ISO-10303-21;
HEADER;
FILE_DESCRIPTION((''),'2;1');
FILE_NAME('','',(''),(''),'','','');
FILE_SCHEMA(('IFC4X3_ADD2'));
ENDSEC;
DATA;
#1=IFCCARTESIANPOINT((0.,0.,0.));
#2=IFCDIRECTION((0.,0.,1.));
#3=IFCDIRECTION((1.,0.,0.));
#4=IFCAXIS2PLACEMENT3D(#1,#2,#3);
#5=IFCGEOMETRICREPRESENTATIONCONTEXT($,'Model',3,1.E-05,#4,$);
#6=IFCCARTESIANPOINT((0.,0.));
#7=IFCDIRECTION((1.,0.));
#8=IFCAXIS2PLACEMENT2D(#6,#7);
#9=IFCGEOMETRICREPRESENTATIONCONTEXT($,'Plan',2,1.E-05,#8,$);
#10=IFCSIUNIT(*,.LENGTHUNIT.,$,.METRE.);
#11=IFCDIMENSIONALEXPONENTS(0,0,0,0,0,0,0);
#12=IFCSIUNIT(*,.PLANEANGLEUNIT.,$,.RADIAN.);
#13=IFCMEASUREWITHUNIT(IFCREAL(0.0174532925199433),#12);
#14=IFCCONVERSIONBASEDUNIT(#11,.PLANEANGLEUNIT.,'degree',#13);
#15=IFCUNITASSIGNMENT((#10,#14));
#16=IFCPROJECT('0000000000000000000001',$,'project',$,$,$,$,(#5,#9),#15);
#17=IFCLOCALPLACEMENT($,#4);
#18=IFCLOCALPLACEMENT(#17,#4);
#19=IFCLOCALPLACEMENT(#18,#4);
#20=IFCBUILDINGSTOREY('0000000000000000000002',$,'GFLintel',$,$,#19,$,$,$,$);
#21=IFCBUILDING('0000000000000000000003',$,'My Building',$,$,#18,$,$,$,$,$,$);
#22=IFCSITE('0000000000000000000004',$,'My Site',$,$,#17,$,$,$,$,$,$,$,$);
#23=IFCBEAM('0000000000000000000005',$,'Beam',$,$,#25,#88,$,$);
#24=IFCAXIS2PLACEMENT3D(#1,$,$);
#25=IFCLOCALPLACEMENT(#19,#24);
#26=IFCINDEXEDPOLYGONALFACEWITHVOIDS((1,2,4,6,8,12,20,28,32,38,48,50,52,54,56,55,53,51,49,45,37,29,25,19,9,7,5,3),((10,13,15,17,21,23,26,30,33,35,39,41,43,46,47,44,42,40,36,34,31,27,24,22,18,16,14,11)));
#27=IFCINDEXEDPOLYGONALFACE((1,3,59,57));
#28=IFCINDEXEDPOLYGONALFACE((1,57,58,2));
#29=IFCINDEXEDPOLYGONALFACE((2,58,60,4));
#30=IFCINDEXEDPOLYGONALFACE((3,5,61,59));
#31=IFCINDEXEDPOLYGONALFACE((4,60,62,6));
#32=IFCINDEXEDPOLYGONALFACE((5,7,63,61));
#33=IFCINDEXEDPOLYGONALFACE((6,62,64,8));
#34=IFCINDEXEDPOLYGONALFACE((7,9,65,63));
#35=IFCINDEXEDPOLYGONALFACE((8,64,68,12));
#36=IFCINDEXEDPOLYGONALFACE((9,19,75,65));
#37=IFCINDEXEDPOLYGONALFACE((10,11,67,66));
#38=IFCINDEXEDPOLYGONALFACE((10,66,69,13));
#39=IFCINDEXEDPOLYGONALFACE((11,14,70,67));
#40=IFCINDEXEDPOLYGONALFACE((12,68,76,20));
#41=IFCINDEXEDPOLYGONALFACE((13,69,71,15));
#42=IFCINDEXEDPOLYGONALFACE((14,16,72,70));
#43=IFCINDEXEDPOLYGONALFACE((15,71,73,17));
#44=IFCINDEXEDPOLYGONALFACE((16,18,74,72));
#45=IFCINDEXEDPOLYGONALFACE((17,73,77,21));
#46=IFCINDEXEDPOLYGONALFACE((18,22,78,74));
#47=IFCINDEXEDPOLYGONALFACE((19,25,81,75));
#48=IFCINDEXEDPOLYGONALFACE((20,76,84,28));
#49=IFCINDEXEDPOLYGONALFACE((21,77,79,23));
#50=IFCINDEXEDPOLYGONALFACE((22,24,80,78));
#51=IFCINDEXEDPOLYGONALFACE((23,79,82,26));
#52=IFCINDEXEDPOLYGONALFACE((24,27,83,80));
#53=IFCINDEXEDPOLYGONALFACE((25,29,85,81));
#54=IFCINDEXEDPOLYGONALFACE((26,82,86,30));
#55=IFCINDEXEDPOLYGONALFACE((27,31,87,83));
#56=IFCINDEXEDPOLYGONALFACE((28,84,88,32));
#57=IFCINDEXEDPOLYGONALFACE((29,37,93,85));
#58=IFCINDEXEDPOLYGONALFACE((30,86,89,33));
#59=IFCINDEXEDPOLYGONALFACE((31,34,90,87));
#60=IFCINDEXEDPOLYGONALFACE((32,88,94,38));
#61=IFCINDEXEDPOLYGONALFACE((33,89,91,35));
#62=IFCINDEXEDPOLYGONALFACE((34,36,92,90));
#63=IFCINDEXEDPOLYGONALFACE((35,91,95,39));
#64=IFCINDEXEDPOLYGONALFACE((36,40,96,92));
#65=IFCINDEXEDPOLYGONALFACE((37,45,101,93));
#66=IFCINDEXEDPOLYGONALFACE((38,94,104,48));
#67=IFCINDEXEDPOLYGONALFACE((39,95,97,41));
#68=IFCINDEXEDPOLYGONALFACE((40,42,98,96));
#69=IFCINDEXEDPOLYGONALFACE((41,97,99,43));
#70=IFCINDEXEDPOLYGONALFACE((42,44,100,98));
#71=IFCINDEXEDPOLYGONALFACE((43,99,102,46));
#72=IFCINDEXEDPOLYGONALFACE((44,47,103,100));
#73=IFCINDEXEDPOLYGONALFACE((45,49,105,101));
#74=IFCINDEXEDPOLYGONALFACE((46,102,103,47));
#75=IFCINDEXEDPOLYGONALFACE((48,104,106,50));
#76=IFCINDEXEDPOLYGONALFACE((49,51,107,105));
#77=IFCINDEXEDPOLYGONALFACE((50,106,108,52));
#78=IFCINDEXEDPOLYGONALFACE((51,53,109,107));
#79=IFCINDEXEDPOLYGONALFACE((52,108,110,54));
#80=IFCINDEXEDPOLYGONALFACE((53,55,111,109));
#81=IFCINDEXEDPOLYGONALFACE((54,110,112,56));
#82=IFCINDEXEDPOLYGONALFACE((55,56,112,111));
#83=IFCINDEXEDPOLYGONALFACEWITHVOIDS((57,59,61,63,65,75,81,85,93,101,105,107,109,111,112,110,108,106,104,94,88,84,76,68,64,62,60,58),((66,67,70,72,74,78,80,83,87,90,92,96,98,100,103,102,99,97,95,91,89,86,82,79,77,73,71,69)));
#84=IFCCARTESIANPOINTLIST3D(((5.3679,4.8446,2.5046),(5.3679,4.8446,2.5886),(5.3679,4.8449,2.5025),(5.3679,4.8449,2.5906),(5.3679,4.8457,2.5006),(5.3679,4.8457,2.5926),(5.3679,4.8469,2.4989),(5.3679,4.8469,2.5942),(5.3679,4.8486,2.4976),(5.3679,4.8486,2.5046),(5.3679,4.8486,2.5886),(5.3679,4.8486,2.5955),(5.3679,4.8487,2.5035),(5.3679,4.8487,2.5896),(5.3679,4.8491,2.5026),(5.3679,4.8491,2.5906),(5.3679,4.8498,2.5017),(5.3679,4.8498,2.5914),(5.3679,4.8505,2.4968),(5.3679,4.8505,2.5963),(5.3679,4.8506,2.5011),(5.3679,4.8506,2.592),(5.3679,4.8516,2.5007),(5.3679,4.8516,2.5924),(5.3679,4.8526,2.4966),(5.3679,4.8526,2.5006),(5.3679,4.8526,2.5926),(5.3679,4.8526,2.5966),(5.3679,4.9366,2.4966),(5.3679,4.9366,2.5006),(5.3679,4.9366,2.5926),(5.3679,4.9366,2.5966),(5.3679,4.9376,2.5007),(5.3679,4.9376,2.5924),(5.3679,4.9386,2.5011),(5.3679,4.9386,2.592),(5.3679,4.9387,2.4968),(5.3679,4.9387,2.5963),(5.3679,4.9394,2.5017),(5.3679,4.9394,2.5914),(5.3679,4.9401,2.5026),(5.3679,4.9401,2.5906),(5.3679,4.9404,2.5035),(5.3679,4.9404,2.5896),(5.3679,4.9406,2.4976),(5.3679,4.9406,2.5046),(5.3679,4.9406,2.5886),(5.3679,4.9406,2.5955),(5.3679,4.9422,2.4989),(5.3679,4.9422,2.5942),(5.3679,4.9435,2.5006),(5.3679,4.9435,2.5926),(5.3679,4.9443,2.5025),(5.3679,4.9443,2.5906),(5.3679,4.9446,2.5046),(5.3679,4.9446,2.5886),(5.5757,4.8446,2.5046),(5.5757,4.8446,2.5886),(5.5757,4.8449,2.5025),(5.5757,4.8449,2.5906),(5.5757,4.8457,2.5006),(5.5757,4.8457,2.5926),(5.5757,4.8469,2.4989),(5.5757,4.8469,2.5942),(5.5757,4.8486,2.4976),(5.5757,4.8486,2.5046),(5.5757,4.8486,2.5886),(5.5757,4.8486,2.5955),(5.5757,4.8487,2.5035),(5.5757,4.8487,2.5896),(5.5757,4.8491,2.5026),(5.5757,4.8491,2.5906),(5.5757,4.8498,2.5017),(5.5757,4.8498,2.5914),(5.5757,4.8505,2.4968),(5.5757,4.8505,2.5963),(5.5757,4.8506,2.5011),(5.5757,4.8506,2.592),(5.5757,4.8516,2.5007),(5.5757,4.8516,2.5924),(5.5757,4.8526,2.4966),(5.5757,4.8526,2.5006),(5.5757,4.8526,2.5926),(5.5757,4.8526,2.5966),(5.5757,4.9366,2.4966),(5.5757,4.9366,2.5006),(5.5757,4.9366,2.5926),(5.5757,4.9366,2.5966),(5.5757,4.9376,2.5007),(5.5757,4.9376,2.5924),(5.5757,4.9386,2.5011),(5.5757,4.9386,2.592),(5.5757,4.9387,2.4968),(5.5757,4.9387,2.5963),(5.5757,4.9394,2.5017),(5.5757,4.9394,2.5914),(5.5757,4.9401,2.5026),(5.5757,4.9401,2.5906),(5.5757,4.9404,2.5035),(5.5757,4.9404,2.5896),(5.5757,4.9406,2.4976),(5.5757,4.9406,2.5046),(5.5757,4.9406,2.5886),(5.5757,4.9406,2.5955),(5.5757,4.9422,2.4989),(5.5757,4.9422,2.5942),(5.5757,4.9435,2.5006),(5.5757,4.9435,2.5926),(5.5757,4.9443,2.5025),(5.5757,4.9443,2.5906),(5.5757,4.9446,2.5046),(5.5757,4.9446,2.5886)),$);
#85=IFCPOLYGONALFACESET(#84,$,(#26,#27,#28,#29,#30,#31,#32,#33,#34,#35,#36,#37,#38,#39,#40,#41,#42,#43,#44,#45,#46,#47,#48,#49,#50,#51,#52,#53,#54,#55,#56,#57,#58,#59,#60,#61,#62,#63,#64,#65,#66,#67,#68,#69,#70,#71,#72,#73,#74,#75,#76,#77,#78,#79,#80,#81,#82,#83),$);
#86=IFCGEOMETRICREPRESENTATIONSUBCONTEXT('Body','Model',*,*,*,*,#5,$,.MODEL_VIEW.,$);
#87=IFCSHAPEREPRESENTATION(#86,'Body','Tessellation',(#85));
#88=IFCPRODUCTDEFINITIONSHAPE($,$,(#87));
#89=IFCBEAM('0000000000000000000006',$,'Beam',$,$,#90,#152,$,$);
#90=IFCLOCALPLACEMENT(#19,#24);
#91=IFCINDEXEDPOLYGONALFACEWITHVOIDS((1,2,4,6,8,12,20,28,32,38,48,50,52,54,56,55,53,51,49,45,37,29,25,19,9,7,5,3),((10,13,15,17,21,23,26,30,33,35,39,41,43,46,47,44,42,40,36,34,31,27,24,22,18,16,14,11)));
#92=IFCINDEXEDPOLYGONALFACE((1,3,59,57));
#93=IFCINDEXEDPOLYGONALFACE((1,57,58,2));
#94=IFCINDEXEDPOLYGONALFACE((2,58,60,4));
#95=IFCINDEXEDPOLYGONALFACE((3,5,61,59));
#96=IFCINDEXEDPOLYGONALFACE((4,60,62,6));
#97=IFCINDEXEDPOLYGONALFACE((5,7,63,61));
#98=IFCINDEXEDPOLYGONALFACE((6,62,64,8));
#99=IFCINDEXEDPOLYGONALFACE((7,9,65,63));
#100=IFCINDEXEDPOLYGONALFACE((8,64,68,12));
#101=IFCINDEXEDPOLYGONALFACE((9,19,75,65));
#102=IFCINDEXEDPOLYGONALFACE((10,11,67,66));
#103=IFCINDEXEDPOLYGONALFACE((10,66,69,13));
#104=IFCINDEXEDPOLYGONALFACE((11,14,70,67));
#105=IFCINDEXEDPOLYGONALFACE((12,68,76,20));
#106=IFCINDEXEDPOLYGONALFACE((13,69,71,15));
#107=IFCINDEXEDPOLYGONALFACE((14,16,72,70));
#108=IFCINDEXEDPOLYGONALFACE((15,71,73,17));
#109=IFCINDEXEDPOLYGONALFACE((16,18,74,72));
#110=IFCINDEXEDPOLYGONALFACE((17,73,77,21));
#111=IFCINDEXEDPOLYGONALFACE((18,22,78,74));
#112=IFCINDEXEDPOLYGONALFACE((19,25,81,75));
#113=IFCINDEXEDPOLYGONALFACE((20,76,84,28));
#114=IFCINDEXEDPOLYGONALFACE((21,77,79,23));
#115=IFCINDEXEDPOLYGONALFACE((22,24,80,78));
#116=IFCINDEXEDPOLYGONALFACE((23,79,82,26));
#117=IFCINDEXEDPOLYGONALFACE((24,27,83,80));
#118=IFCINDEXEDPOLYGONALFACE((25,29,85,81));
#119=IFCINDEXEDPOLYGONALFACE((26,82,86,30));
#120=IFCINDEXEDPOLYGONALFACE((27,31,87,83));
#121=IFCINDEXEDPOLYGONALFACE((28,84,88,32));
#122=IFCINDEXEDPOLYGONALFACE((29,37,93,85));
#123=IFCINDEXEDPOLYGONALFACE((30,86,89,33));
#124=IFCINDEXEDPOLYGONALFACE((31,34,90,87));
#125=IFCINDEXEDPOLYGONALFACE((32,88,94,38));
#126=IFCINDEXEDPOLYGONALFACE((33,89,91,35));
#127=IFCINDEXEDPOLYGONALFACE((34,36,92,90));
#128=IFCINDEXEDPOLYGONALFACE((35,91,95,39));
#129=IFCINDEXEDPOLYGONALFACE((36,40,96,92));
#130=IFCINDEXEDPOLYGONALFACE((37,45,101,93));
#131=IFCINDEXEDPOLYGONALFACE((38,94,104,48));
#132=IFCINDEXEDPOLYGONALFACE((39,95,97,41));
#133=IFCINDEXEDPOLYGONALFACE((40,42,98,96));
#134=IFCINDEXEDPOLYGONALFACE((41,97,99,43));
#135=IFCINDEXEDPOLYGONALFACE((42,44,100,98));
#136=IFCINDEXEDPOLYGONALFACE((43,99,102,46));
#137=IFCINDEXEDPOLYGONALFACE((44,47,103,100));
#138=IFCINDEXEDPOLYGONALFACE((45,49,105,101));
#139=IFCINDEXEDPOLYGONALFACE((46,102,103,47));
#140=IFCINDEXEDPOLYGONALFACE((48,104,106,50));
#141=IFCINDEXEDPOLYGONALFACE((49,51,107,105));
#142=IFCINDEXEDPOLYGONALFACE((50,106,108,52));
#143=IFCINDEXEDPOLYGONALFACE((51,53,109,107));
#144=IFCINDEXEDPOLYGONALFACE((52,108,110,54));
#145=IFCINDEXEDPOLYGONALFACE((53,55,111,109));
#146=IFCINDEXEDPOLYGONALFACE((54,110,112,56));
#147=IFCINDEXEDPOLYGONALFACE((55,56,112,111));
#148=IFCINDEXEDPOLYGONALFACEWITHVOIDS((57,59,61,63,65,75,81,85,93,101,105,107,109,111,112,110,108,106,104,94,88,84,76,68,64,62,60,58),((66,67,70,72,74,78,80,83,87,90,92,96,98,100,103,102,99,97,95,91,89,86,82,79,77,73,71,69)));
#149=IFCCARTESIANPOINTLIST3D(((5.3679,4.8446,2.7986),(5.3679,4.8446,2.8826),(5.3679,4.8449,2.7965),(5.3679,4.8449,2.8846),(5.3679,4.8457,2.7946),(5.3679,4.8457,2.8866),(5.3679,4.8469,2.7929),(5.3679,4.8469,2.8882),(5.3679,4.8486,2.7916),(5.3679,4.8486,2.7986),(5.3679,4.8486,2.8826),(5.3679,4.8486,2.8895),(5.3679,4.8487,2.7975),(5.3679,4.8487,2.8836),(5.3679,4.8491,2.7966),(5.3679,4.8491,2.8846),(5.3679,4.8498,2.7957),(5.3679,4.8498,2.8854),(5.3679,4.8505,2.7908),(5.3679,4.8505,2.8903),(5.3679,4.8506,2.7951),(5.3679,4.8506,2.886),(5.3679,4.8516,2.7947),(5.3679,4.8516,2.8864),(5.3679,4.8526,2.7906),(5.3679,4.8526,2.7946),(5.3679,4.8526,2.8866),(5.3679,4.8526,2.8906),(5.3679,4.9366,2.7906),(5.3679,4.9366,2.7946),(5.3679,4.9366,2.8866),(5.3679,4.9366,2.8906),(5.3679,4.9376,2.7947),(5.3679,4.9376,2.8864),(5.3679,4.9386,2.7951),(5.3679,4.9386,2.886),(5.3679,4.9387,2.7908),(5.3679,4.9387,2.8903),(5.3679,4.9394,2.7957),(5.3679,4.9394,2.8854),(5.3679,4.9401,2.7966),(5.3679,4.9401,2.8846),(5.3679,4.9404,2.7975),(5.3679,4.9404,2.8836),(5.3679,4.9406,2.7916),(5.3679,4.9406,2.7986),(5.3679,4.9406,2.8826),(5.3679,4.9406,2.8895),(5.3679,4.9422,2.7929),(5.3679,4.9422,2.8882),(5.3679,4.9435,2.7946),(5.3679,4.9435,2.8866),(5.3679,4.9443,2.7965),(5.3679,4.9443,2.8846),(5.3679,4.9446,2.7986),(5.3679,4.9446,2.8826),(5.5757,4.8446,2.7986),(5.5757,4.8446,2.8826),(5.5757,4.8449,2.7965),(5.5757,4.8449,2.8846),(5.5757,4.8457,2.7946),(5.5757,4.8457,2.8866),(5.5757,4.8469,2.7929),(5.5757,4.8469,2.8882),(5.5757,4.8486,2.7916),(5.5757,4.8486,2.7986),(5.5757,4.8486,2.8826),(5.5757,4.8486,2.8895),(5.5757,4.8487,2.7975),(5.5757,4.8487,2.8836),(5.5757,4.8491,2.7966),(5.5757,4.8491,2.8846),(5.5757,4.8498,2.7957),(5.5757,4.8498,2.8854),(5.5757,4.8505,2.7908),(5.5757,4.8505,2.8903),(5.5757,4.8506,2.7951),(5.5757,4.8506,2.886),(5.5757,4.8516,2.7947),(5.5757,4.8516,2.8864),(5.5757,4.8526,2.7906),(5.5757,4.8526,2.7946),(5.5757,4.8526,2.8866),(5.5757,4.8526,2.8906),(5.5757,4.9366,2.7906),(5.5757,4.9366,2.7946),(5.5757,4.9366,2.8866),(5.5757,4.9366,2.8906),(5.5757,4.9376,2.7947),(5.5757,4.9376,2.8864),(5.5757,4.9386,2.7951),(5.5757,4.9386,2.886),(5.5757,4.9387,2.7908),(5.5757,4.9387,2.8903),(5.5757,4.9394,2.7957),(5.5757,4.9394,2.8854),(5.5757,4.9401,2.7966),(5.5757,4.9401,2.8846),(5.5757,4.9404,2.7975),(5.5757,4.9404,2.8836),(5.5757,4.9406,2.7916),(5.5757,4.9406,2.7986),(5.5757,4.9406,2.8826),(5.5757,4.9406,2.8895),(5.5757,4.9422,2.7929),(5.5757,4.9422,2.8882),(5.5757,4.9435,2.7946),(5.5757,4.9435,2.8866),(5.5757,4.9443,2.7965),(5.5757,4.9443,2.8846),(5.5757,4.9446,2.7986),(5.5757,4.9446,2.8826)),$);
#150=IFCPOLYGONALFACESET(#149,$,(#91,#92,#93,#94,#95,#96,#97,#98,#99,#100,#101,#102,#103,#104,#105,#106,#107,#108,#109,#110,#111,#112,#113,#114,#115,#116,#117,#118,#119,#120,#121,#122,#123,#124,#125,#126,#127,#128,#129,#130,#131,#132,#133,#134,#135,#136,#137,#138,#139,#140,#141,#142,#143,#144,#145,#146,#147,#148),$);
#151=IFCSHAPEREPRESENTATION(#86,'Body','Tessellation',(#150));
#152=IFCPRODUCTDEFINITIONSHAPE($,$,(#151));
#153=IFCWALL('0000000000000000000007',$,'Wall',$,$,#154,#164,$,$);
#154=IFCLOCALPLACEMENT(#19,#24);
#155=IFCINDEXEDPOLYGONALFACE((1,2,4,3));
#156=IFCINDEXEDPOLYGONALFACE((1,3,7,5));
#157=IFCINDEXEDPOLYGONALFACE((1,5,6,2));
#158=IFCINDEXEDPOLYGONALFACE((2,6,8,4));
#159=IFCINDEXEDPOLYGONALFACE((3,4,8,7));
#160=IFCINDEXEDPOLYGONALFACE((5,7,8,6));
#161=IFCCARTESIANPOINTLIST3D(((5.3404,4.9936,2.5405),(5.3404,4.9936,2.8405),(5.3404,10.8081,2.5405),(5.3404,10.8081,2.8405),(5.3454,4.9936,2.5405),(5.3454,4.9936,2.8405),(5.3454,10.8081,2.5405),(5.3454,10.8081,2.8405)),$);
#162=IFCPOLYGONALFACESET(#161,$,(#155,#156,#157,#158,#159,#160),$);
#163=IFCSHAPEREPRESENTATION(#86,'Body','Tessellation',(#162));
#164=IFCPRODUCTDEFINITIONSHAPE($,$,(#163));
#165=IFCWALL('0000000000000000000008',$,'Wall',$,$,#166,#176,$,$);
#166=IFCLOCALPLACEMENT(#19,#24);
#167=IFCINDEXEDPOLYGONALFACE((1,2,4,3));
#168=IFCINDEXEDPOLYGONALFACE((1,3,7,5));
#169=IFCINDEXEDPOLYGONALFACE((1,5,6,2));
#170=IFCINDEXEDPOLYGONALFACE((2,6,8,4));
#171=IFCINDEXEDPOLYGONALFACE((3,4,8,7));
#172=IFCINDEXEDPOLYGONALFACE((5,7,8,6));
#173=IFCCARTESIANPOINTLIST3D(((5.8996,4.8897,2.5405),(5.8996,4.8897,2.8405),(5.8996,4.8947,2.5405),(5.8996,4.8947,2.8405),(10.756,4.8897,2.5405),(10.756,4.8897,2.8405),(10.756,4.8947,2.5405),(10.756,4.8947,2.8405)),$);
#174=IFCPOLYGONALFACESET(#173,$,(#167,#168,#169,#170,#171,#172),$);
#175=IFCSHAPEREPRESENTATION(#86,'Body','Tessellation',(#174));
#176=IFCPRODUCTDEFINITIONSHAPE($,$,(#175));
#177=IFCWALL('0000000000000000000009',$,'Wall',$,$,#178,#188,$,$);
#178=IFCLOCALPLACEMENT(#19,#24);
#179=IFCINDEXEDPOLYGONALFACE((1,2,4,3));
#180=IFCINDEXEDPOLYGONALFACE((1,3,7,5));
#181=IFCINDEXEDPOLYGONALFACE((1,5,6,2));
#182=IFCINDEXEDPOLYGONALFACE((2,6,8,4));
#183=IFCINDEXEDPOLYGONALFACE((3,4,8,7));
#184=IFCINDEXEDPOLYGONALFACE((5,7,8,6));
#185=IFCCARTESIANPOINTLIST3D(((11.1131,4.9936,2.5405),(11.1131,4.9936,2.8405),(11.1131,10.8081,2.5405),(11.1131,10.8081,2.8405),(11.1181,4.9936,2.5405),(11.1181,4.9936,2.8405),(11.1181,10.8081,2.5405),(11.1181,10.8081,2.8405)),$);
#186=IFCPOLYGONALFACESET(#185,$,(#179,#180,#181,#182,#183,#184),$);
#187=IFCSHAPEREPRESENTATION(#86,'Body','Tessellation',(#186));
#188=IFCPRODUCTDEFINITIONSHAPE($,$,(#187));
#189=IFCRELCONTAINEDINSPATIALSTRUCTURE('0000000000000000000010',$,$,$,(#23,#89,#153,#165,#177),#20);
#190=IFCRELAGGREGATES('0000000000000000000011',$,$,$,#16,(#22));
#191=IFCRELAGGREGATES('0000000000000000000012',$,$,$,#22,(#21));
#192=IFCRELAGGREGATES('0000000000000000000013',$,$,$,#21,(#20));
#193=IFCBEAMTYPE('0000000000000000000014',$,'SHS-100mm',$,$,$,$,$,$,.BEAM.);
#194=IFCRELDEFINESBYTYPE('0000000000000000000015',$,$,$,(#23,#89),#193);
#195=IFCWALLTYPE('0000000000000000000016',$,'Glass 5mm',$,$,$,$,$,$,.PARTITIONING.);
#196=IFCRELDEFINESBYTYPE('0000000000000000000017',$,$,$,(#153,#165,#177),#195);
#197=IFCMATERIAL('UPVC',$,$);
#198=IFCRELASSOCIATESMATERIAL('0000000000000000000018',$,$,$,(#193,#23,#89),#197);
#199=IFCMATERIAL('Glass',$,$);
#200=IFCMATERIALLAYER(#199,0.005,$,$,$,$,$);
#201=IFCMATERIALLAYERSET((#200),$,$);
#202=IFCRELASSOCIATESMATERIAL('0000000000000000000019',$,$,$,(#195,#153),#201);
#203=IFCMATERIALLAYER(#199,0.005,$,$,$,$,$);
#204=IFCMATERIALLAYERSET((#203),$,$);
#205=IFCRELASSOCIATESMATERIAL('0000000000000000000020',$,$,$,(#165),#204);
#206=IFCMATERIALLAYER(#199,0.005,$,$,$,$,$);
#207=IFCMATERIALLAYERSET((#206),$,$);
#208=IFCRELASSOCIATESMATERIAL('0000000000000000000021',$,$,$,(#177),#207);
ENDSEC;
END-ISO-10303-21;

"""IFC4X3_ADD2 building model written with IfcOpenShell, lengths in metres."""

from ifc_helpers import new_model, entity, si_unit, converted_unit, frame, origin_with_axes, origin_2d_with_axis, place, context, subcontext, project, spatial, line, indexed_curve, hollow_rectangle, outline, extrude, material, layer, layer_set, layer_usage, material_profile, profile_set, profile_usage, type_object, element, save


model = new_model("IFC4X3_ADD2")

# Units and contexts
model_context = context("Model", 3, precision=1e-05, world=origin_with_axes())
plan_context = context("Plan", 2, precision=1e-05, world=origin_2d_with_axis())
body_context = subcontext(model_context, "Body", "Model", "MODEL_VIEW")
ifc_project = project(units=[si_unit("LENGTHUNIT", "METRE"), converted_unit("PLANEANGLEUNIT", "degree", entity("IfcReal", 0.0174532925199433), si_unit("PLANEANGLEUNIT", "RADIAN"), dimensions=[0, 0, 0, 0, 0, 0, 0])], contexts=[model_context, plan_context])

# Site, building, storey
site_placement = place(None, origin_with_axes())
site = spatial("IfcSite", under=ifc_project, at=site_placement, Name="My Site")
building_placement = place(site_placement, origin_with_axes())
building = spatial("IfcBuilding", under=site, at=building_placement, Name="My Building")
storey_placement = place(building_placement, origin_with_axes())
storey = spatial("IfcBuildingStorey", under=building, at=storey_placement, Name="GFLintel")

# Beams
ifc_material_1 = material(Name="UPVC")
ifc_material_profile_1 = material_profile(ifc_material_1, hollow_rectangle(XDim=0.1, YDim=0.1, WallThickness=0.004, InnerFilletRadius=0.004, OuterFilletRadius=0.008))
ifc_profile_set_1 = profile_set([ifc_material_profile_1])
beam_type_1 = type_object("IfcBeamType", Name="SHS-100mm", PredefinedType="BEAM", material=ifc_profile_set_1)
ifc_profile_usage_1 = profile_usage(ifc_profile_set_1, cardinal=5)
beam_1_placement = place(storey_placement, frame((5.3679, 4.8946, 2.5466), z_axis=(1.0, 0.0, 0.000001), x_axis=(0.0, 1.0, 0.0)))
element("IfcBeam", 1, at=beam_1_placement, inside=storey, type_object=beam_type_1, material=ifc_profile_usage_1, Name="Beam", context=body_context, shape_type="SweptSolid", body=[
    extrude(hollow_rectangle(XDim=0.1, YDim=0.1, WallThickness=0.004, InnerFilletRadius=0.004, OuterFilletRadius=0.008), origin_with_axes(), (0.0, 0.0, 1.0), 0.2078),
])
ifc_profile_usage_2 = profile_usage(ifc_profile_set_1, cardinal=5)
beam_2_placement = place(storey_placement, frame((5.3679, 4.8946, 2.8406), z_axis=(1.0, 0.0, 0.000001), x_axis=(0.0, 1.0, 0.0)))
element("IfcBeam", 2, at=beam_2_placement, inside=storey, type_object=beam_type_1, material=ifc_profile_usage_2, Name="Beam", context=body_context, shape_type="SweptSolid", body=[
    extrude(hollow_rectangle(XDim=0.1, YDim=0.1, WallThickness=0.004, InnerFilletRadius=0.004, OuterFilletRadius=0.008), origin_with_axes(), (0.0, 0.0, 1.0), 0.2078),
])

# Walls
ifc_material_2 = material(Name="Glass")
ifc_layer_1 = layer(ifc_material_2, 0.005)
ifc_layer_set_1 = layer_set([ifc_layer_1])
ifc_layer_usage_1 = layer_usage(ifc_layer_set_1, "AXIS2", "POSITIVE", 0.0)
wall_type = type_object("IfcWallType", Name="Glass 5mm", PredefinedType="PARTITIONING", material=ifc_layer_set_1)
wall_1_placement = place(storey_placement, frame((5.3454, 4.9936, 2.5405), z_axis=(0.0, 0.0, 1.0), x_axis=(0.0, 1.0, 0.0)))
element("IfcWall", 3, at=wall_1_placement, inside=storey, type_object=wall_type, material=ifc_layer_usage_1, Name="Wall", context=body_context, shape_type="SweptSolid", body=[
    extrude(outline(indexed_curve([(0.0, 0.0), (0.0, 0.005), (5.8145, 0.005), (5.8145, 0.0)], segments=[line(1, 2, 3, 4, 1)])), origin_with_axes(), (0.0, 0.0, 1.0), 0.3),
])
ifc_layer_2 = layer(ifc_material_2, 0.005)
ifc_layer_set_2 = layer_set([ifc_layer_2])
ifc_layer_usage_2 = layer_usage(ifc_layer_set_2, "AXIS2", "POSITIVE", 0.0)
wall_2_placement = place(storey_placement, frame((5.8996, 4.8897, 2.5405), z_axis=(0.0, 0.0, 1.0), x_axis=(1.0, 0.0, 0.0)))
element("IfcWall", 4, at=wall_2_placement, inside=storey, type_object=wall_type, material=ifc_layer_usage_2, Name="Wall", context=body_context, shape_type="SweptSolid", body=[
    extrude(outline(indexed_curve([(0.0, 0.0), (0.0, 0.005), (4.8564, 0.005), (4.8564, 0.0)], segments=[line(1, 2, 3, 4, 1)])), origin_with_axes(), (0.0, 0.0, 1.0), 0.3),
])
ifc_layer_3 = layer(ifc_material_2, 0.005)
ifc_layer_set_3 = layer_set([ifc_layer_3])
ifc_layer_usage_3 = layer_usage(ifc_layer_set_3, "AXIS2", "POSITIVE", 0.0)
wall_3_placement = place(storey_placement, frame((11.1181, 4.9936, 2.5405), z_axis=(0.0, 0.0, 1.0), x_axis=(0.0, 1.0, 0.0)))
element("IfcWall", 5, at=wall_3_placement, inside=storey, type_object=wall_type, material=ifc_layer_usage_3, Name="Wall", context=body_context, shape_type="SweptSolid", body=[
    extrude(outline(indexed_curve([(0.0, 0.0), (0.0, 0.005), (5.8145, 0.005), (5.8145, 0.0)], segments=[line(1, 2, 3, 4, 1)])), origin_with_axes(), (0.0, 0.0, 1.0), 0.3),
])

save(model, "model.ifc")
